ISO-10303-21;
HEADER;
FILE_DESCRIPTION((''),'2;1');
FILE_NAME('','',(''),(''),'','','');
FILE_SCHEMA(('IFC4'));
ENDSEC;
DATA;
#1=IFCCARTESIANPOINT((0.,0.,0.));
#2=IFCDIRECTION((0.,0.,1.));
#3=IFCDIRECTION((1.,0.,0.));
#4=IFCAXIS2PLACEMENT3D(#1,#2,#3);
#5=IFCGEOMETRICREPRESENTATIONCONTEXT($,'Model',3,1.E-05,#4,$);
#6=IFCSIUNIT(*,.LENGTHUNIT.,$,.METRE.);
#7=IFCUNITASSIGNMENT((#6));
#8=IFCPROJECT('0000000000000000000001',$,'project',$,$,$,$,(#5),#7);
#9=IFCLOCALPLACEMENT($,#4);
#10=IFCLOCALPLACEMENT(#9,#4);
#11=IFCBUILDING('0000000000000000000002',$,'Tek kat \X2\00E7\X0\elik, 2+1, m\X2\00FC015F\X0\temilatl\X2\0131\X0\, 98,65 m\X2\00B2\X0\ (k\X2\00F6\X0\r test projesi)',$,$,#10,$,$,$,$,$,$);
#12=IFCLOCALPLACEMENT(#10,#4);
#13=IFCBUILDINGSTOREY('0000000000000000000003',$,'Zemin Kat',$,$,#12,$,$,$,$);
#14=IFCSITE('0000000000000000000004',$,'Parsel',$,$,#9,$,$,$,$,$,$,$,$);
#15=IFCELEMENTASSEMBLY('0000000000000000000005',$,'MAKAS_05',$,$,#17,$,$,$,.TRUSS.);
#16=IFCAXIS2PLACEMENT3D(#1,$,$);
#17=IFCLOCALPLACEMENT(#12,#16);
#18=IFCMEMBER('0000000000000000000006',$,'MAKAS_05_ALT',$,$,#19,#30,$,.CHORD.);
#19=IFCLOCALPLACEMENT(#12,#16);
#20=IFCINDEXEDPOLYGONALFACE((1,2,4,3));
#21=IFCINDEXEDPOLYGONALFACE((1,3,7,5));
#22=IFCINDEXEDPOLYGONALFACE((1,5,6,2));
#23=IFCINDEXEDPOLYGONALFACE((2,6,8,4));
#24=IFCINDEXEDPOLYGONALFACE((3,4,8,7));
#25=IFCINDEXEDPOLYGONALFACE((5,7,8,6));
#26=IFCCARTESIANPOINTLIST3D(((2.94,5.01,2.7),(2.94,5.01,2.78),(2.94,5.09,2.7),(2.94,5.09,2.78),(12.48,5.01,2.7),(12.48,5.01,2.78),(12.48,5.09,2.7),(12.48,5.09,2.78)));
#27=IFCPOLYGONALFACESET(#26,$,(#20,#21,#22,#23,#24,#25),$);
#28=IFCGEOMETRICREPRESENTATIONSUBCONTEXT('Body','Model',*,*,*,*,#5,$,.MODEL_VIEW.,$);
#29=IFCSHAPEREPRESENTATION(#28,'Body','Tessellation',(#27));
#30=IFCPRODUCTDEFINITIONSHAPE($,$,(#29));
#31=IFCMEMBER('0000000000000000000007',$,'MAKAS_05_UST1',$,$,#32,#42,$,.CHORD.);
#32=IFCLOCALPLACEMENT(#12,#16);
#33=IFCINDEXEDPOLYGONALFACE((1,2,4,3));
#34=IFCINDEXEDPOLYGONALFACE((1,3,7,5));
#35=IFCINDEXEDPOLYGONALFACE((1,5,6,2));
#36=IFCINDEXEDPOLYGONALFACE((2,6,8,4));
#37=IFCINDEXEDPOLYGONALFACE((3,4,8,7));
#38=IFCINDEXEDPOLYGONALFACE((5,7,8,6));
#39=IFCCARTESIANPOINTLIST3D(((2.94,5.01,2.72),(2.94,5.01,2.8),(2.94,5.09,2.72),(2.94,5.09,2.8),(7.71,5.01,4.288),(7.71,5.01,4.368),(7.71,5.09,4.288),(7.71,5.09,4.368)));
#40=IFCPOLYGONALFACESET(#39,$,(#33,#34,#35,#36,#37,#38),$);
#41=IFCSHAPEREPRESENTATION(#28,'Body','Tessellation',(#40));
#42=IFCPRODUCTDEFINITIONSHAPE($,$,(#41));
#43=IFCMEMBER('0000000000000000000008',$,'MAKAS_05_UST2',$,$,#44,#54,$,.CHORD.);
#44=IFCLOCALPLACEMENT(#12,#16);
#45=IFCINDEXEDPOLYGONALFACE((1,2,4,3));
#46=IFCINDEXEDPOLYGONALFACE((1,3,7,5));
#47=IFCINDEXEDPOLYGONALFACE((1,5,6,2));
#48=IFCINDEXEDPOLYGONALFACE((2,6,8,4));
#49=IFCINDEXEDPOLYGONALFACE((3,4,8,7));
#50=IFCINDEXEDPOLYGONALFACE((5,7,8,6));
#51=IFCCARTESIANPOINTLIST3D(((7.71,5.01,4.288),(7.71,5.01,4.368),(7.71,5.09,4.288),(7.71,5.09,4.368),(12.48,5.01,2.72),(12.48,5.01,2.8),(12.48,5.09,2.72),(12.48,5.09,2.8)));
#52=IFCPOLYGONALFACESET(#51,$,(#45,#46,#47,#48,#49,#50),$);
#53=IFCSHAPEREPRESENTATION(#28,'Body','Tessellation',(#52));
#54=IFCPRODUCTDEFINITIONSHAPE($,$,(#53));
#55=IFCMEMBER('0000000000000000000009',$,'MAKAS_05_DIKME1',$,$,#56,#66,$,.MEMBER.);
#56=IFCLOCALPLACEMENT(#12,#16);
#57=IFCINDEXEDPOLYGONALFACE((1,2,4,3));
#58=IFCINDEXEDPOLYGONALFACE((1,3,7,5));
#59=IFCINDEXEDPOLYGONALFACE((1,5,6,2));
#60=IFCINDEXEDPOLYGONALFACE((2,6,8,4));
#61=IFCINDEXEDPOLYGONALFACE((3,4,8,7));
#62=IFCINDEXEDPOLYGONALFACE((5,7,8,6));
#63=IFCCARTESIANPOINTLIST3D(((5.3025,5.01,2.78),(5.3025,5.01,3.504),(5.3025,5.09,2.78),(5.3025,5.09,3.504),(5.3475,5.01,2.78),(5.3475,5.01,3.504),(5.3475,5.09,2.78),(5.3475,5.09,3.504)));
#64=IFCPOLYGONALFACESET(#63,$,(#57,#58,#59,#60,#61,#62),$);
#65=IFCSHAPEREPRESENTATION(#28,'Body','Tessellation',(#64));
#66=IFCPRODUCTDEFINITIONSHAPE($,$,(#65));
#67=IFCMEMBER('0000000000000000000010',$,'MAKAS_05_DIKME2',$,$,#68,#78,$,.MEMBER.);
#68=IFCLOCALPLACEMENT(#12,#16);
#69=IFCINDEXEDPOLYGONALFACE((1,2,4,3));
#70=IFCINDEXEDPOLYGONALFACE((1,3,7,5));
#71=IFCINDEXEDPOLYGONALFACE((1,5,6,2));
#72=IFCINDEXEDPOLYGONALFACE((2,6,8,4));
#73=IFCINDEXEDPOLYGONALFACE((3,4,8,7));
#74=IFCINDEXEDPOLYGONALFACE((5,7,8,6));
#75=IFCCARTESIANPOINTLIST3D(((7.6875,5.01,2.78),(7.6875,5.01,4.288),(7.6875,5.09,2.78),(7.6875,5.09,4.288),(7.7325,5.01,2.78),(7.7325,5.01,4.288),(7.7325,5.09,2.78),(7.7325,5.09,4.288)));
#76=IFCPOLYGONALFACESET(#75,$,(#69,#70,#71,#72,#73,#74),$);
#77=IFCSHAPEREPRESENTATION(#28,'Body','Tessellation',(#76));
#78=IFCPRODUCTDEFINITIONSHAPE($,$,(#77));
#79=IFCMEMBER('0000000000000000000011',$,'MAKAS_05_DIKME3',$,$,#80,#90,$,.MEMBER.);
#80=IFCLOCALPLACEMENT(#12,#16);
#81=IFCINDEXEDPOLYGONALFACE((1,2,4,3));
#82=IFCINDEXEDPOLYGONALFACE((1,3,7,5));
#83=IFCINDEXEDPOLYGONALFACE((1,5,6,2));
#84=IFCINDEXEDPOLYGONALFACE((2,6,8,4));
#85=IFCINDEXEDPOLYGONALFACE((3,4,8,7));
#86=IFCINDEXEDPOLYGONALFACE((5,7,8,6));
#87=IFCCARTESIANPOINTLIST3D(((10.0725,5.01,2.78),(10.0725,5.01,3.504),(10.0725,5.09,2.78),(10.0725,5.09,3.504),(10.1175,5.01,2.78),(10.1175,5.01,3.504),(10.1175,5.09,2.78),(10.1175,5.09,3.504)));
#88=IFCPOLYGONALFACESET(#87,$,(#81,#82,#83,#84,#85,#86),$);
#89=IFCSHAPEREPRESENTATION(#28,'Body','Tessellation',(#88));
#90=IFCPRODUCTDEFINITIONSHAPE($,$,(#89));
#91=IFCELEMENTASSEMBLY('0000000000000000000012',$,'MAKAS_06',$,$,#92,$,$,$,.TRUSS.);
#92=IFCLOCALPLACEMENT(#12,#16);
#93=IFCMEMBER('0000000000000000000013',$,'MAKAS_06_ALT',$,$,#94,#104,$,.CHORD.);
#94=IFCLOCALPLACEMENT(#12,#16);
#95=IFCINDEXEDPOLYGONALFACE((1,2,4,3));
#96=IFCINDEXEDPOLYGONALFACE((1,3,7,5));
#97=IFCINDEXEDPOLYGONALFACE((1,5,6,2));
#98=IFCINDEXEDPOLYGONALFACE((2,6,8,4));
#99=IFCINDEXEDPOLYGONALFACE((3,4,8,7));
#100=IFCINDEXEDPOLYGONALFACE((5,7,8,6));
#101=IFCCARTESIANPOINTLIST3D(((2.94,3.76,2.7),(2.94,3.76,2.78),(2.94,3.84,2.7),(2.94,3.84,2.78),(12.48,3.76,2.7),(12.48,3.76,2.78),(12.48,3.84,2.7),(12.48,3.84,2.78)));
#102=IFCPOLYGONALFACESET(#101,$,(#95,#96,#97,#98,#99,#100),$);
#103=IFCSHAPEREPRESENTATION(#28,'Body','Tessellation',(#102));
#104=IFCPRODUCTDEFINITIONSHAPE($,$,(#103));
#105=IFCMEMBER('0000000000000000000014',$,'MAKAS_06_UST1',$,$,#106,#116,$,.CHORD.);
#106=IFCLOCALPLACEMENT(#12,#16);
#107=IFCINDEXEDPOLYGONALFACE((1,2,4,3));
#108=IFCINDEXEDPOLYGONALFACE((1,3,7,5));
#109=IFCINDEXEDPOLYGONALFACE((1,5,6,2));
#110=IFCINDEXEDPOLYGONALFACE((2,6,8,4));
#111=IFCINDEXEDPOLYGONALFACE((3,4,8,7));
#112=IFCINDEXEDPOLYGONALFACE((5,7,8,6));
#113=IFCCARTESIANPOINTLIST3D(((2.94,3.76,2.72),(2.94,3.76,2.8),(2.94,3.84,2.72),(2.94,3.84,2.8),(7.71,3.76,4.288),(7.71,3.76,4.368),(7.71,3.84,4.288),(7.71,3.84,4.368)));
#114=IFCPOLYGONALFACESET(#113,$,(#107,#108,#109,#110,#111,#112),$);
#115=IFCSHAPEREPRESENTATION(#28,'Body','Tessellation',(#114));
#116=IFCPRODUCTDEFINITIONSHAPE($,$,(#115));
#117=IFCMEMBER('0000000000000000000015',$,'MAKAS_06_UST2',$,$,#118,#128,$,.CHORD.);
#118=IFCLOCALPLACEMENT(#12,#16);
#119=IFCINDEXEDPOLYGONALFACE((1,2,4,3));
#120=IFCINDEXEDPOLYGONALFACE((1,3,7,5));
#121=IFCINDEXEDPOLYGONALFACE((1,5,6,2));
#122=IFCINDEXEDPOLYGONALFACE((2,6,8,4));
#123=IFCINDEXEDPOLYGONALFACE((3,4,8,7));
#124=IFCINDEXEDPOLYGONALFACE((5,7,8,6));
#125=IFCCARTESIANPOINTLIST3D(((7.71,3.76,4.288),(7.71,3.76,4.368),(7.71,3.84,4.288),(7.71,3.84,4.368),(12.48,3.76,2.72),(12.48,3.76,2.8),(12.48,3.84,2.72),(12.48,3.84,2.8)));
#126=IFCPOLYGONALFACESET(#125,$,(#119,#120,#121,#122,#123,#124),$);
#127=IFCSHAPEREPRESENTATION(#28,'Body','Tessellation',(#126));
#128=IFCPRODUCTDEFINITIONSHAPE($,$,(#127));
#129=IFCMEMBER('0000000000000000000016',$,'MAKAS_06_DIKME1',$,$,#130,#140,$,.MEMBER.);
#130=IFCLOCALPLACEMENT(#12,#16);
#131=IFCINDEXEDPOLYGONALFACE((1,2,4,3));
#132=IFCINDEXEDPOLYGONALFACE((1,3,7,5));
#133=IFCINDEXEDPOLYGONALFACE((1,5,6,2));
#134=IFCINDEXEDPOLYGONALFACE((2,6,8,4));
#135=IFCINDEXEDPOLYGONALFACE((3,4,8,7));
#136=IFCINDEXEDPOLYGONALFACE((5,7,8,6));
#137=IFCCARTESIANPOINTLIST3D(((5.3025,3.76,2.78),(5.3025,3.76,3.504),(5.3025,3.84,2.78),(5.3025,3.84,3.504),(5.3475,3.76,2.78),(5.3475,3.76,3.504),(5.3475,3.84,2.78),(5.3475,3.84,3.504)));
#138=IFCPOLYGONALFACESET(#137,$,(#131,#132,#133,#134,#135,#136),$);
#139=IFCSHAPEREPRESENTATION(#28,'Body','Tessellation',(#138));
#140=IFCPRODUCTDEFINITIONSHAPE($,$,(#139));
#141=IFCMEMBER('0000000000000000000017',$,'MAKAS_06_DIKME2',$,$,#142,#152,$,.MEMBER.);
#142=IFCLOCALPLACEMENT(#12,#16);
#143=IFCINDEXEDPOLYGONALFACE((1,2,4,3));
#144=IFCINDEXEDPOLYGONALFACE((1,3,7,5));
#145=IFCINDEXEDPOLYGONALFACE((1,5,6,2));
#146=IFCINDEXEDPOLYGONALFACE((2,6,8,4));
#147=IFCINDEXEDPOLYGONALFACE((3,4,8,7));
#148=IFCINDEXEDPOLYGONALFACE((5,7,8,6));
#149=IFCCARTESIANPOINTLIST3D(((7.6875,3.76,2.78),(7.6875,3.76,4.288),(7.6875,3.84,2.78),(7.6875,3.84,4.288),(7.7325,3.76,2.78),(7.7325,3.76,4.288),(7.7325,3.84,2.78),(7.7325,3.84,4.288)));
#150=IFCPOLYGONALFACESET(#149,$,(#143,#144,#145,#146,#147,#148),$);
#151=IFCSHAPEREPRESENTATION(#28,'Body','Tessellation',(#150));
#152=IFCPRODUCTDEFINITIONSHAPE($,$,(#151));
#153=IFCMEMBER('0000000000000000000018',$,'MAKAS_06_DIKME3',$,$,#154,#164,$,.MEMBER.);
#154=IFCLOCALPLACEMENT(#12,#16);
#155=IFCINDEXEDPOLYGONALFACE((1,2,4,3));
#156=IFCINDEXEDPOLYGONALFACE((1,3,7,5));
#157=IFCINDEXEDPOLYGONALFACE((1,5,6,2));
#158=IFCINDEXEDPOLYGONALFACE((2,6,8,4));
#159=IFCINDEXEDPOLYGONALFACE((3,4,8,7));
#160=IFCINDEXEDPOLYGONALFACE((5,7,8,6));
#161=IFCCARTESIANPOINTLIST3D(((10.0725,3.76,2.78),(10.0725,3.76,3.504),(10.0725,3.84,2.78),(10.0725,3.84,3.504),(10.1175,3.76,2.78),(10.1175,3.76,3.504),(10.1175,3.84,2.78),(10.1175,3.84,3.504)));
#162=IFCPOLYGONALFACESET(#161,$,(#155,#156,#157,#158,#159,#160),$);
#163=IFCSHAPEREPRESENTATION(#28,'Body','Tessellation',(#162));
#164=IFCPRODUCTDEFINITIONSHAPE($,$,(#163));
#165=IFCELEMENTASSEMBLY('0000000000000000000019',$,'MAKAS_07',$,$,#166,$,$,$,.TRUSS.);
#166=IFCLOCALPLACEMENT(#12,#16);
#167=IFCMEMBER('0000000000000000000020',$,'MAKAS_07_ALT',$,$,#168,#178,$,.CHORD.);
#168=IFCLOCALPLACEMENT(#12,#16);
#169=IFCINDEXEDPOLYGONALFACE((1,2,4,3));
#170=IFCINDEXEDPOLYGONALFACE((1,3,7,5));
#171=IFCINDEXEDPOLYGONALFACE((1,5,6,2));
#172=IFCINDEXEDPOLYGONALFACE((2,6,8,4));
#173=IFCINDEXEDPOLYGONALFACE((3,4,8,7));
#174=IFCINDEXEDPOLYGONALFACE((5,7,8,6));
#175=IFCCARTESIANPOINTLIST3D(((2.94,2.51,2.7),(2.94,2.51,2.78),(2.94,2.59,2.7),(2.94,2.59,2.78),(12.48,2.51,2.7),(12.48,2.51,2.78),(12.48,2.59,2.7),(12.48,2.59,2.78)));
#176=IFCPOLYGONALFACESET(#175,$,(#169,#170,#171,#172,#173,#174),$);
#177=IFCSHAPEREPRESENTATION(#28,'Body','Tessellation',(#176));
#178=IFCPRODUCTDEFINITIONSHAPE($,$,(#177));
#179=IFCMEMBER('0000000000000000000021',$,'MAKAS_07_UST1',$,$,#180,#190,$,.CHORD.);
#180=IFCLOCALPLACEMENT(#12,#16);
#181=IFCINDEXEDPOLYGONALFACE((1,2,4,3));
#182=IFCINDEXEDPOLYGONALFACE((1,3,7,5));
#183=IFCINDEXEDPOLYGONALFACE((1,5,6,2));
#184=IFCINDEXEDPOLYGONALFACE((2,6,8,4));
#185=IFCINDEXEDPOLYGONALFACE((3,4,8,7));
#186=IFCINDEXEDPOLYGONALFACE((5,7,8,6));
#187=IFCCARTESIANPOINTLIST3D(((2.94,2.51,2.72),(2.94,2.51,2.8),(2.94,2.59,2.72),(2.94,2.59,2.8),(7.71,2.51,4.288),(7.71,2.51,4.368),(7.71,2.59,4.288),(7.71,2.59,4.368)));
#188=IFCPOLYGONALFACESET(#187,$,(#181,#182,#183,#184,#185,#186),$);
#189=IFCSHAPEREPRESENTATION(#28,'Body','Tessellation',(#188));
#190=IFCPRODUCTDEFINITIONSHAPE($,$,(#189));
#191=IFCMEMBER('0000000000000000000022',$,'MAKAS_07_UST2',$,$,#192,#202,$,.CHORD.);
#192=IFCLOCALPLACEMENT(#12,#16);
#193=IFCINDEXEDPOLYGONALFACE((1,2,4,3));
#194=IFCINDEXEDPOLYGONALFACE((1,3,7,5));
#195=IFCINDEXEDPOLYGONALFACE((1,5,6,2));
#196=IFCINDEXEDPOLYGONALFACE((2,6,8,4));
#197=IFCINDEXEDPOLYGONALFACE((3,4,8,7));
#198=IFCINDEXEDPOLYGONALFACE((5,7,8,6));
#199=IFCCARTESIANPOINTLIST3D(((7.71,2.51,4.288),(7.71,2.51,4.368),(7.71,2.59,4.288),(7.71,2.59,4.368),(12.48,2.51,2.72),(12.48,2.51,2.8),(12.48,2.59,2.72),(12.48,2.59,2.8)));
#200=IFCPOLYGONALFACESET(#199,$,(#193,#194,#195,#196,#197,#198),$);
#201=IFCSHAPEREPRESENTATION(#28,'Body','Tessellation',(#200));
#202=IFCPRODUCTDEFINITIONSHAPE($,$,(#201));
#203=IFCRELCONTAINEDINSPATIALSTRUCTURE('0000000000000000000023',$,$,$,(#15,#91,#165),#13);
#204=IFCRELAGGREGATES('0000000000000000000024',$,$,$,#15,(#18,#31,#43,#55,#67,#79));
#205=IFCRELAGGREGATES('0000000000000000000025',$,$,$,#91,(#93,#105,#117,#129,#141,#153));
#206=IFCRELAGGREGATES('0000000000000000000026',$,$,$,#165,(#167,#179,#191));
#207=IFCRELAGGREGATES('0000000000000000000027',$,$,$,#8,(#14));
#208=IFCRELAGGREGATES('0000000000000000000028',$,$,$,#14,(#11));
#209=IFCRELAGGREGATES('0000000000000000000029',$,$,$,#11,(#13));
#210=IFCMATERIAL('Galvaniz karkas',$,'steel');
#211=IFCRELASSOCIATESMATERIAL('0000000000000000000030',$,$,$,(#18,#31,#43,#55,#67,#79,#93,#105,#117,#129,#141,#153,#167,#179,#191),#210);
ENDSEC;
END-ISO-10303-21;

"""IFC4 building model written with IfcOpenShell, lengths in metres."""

from ifc_helpers import new_model, si_unit, frame, origin_with_axes, place, context, subcontext, project, spatial, line, indexed_curve, outline, extrude, material, element, aggregate, save


model = new_model("IFC4")

# Units and contexts
model_context = context("Model", 3, precision=1e-05, world=origin_with_axes())
body_context = subcontext(model_context, "Body", "Model", "MODEL_VIEW")
ifc_project = project(units=[si_unit("LENGTHUNIT", "METRE")], contexts=[model_context])

# Site, building, storey
site_placement = place(None, origin_with_axes())
site = spatial("IfcSite", under=ifc_project, at=site_placement, Name="Parsel")
building_placement = place(site_placement, origin_with_axes())
building = spatial("IfcBuilding", under=site, at=building_placement, Name="Tek kat çelik, 2+1, müştemilatlı, 98,65 m² (kör test projesi)")
storey_placement = place(building_placement, origin_with_axes())
storey = spatial("IfcBuildingStorey", under=building, at=storey_placement, Name="Zemin Kat")

# Element assemblies, members
assembly_1_placement = place(storey_placement, origin_with_axes())
assembly_1 = element("IfcElementAssembly", 1, at=assembly_1_placement, inside=storey, Name="MAKAS_05", PredefinedType="TRUSS")
ifc_material = material(Name="Galvaniz karkas", Category="steel")
member_1_placement = place(assembly_1_placement, origin_with_axes())
member_1 = element("IfcMember", 2, at=member_1_placement, material=ifc_material, Name="MAKAS_05_ALT", PredefinedType="CHORD", context=body_context, shape_type="SweptSolid", body=[
    extrude(outline(indexed_curve([(2.94, 2.7), (12.48, 2.7), (12.48, 2.78), (2.94, 2.78)], segments=[line(1, 2, 3, 4, 1)])), frame((0.0, 5.09, 0.0), z_axis=(0.0, -1.0, 0.0), x_axis=(1.0, 0.0, 0.0)), (0.0, 0.0, 1.0), 0.08),
])
member_2_placement = place(assembly_1_placement, origin_with_axes())
member_2 = element("IfcMember", 3, at=member_2_placement, material=ifc_material, Name="MAKAS_05_UST1", PredefinedType="CHORD", context=body_context, shape_type="SweptSolid", body=[
    extrude(outline(indexed_curve([(2.94, 2.72), (7.71, 4.288), (7.71, 4.368), (2.94, 2.8)], segments=[line(1, 2, 3, 4, 1)])), frame((0.0, 5.09, 0.0), z_axis=(0.0, -1.0, 0.0), x_axis=(1.0, 0.0, 0.0)), (0.0, 0.0, 1.0), 0.08),
])
member_3_placement = place(assembly_1_placement, origin_with_axes())
member_3 = element("IfcMember", 4, at=member_3_placement, material=ifc_material, Name="MAKAS_05_UST2", PredefinedType="CHORD", context=body_context, shape_type="SweptSolid", body=[
    extrude(outline(indexed_curve([(7.71, 4.288), (12.48, 2.72), (12.48, 2.8), (7.71, 4.368)], segments=[line(1, 2, 3, 4, 1)])), frame((0.0, 5.09, 0.0), z_axis=(0.0, -1.0, 0.0), x_axis=(1.0, 0.0, 0.0)), (0.0, 0.0, 1.0), 0.08),
])
member_4_placement = place(assembly_1_placement, origin_with_axes())
member_4 = element("IfcMember", 5, at=member_4_placement, material=ifc_material, Name="MAKAS_05_DIKME1", PredefinedType="MEMBER", context=body_context, shape_type="SweptSolid", body=[
    extrude(outline(indexed_curve([(5.3025, 2.78), (5.3475, 2.78), (5.3475, 3.504), (5.3025, 3.504)], segments=[line(1, 2, 3, 4, 1)])), frame((0.0, 5.09, 0.0), z_axis=(0.0, -1.0, 0.0), x_axis=(1.0, 0.0, 0.0)), (0.0, 0.0, 1.0), 0.08),
])
member_5_placement = place(assembly_1_placement, origin_with_axes())
member_5 = element("IfcMember", 6, at=member_5_placement, material=ifc_material, Name="MAKAS_05_DIKME2", PredefinedType="MEMBER", context=body_context, shape_type="SweptSolid", body=[
    extrude(outline(indexed_curve([(7.6875, 2.78), (7.7325, 2.78), (7.7325, 4.288), (7.6875, 4.288)], segments=[line(1, 2, 3, 4, 1)])), frame((0.0, 5.09, 0.0), z_axis=(0.0, -1.0, 0.0), x_axis=(1.0, 0.0, 0.0)), (0.0, 0.0, 1.0), 0.08),
])
member_6_placement = place(assembly_1_placement, origin_with_axes())
member_6 = element("IfcMember", 7, at=member_6_placement, material=ifc_material, Name="MAKAS_05_DIKME3", PredefinedType="MEMBER", context=body_context, shape_type="SweptSolid", body=[
    extrude(outline(indexed_curve([(10.0725, 2.78), (10.1175, 2.78), (10.1175, 3.504), (10.0725, 3.504)], segments=[line(1, 2, 3, 4, 1)])), frame((0.0, 5.09, 0.0), z_axis=(0.0, -1.0, 0.0), x_axis=(1.0, 0.0, 0.0)), (0.0, 0.0, 1.0), 0.08),
])
aggregate(assembly_1, [member_1, member_2, member_3, member_4, member_5, member_6])
assembly_2_placement = place(storey_placement, origin_with_axes())
assembly_2 = element("IfcElementAssembly", 8, at=assembly_2_placement, inside=storey, Name="MAKAS_06", PredefinedType="TRUSS")
member_7_placement = place(assembly_2_placement, origin_with_axes())
member_7 = element("IfcMember", 9, at=member_7_placement, material=ifc_material, Name="MAKAS_06_ALT", PredefinedType="CHORD", context=body_context, shape_type="SweptSolid", body=[
    extrude(outline(indexed_curve([(2.94, 2.7), (12.48, 2.7), (12.48, 2.78), (2.94, 2.78)], segments=[line(1, 2, 3, 4, 1)])), frame((0.0, 3.84, 0.0), z_axis=(0.0, -1.0, 0.0), x_axis=(1.0, 0.0, 0.0)), (0.0, 0.0, 1.0), 0.08),
])
member_8_placement = place(assembly_2_placement, origin_with_axes())
member_8 = element("IfcMember", 10, at=member_8_placement, material=ifc_material, Name="MAKAS_06_UST1", PredefinedType="CHORD", context=body_context, shape_type="SweptSolid", body=[
    extrude(outline(indexed_curve([(2.94, 2.72), (7.71, 4.288), (7.71, 4.368), (2.94, 2.8)], segments=[line(1, 2, 3, 4, 1)])), frame((0.0, 3.84, 0.0), z_axis=(0.0, -1.0, 0.0), x_axis=(1.0, 0.0, 0.0)), (0.0, 0.0, 1.0), 0.08),
])
member_9_placement = place(assembly_2_placement, origin_with_axes())
member_9 = element("IfcMember", 11, at=member_9_placement, material=ifc_material, Name="MAKAS_06_UST2", PredefinedType="CHORD", context=body_context, shape_type="SweptSolid", body=[
    extrude(outline(indexed_curve([(7.71, 4.288), (12.48, 2.72), (12.48, 2.8), (7.71, 4.368)], segments=[line(1, 2, 3, 4, 1)])), frame((0.0, 3.84, 0.0), z_axis=(0.0, -1.0, 0.0), x_axis=(1.0, 0.0, 0.0)), (0.0, 0.0, 1.0), 0.08),
])
member_10_placement = place(assembly_2_placement, origin_with_axes())
member_10 = element("IfcMember", 12, at=member_10_placement, material=ifc_material, Name="MAKAS_06_DIKME1", PredefinedType="MEMBER", context=body_context, shape_type="SweptSolid", body=[
    extrude(outline(indexed_curve([(5.3025, 2.78), (5.3475, 2.78), (5.3475, 3.504), (5.3025, 3.504)], segments=[line(1, 2, 3, 4, 1)])), frame((0.0, 3.84, 0.0), z_axis=(0.0, -1.0, 0.0), x_axis=(1.0, 0.0, 0.0)), (0.0, 0.0, 1.0), 0.08),
])
member_11_placement = place(assembly_2_placement, origin_with_axes())
member_11 = element("IfcMember", 13, at=member_11_placement, material=ifc_material, Name="MAKAS_06_DIKME2", PredefinedType="MEMBER", context=body_context, shape_type="SweptSolid", body=[
    extrude(outline(indexed_curve([(7.6875, 2.78), (7.7325, 2.78), (7.7325, 4.288), (7.6875, 4.288)], segments=[line(1, 2, 3, 4, 1)])), frame((0.0, 3.84, 0.0), z_axis=(0.0, -1.0, 0.0), x_axis=(1.0, 0.0, 0.0)), (0.0, 0.0, 1.0), 0.08),
])
member_12_placement = place(assembly_2_placement, origin_with_axes())
member_12 = element("IfcMember", 14, at=member_12_placement, material=ifc_material, Name="MAKAS_06_DIKME3", PredefinedType="MEMBER", context=body_context, shape_type="SweptSolid", body=[
    extrude(outline(indexed_curve([(10.0725, 2.78), (10.1175, 2.78), (10.1175, 3.504), (10.0725, 3.504)], segments=[line(1, 2, 3, 4, 1)])), frame((0.0, 3.84, 0.0), z_axis=(0.0, -1.0, 0.0), x_axis=(1.0, 0.0, 0.0)), (0.0, 0.0, 1.0), 0.08),
])
aggregate(assembly_2, [member_7, member_8, member_9, member_10, member_11, member_12])
assembly_3_placement = place(storey_placement, origin_with_axes())
assembly_3 = element("IfcElementAssembly", 15, at=assembly_3_placement, inside=storey, Name="MAKAS_07", PredefinedType="TRUSS")
member_13_placement = place(assembly_3_placement, origin_with_axes())
member_13 = element("IfcMember", 16, at=member_13_placement, material=ifc_material, Name="MAKAS_07_ALT", PredefinedType="CHORD", context=body_context, shape_type="SweptSolid", body=[
    extrude(outline(indexed_curve([(2.94, 2.7), (12.48, 2.7), (12.48, 2.78), (2.94, 2.78)], segments=[line(1, 2, 3, 4, 1)])), frame((0.0, 2.59, 0.0), z_axis=(0.0, -1.0, 0.0), x_axis=(1.0, 0.0, 0.0)), (0.0, 0.0, 1.0), 0.08),
])
member_14_placement = place(assembly_3_placement, origin_with_axes())
member_14 = element("IfcMember", 17, at=member_14_placement, material=ifc_material, Name="MAKAS_07_UST1", PredefinedType="CHORD", context=body_context, shape_type="SweptSolid", body=[
    extrude(outline(indexed_curve([(2.94, 2.72), (7.71, 4.288), (7.71, 4.368), (2.94, 2.8)], segments=[line(1, 2, 3, 4, 1)])), frame((0.0, 2.59, 0.0), z_axis=(0.0, -1.0, 0.0), x_axis=(1.0, 0.0, 0.0)), (0.0, 0.0, 1.0), 0.08),
])
member_15_placement = place(assembly_3_placement, origin_with_axes())
member_15 = element("IfcMember", 18, at=member_15_placement, material=ifc_material, Name="MAKAS_07_UST2", PredefinedType="CHORD", context=body_context, shape_type="SweptSolid", body=[
    extrude(outline(indexed_curve([(7.71, 4.288), (12.48, 2.72), (12.48, 2.8), (7.71, 4.368)], segments=[line(1, 2, 3, 4, 1)])), frame((0.0, 2.59, 0.0), z_axis=(0.0, -1.0, 0.0), x_axis=(1.0, 0.0, 0.0)), (0.0, 0.0, 1.0), 0.08),
])
aggregate(assembly_3, [member_13, member_14, member_15])

save(model, "model.ifc")
